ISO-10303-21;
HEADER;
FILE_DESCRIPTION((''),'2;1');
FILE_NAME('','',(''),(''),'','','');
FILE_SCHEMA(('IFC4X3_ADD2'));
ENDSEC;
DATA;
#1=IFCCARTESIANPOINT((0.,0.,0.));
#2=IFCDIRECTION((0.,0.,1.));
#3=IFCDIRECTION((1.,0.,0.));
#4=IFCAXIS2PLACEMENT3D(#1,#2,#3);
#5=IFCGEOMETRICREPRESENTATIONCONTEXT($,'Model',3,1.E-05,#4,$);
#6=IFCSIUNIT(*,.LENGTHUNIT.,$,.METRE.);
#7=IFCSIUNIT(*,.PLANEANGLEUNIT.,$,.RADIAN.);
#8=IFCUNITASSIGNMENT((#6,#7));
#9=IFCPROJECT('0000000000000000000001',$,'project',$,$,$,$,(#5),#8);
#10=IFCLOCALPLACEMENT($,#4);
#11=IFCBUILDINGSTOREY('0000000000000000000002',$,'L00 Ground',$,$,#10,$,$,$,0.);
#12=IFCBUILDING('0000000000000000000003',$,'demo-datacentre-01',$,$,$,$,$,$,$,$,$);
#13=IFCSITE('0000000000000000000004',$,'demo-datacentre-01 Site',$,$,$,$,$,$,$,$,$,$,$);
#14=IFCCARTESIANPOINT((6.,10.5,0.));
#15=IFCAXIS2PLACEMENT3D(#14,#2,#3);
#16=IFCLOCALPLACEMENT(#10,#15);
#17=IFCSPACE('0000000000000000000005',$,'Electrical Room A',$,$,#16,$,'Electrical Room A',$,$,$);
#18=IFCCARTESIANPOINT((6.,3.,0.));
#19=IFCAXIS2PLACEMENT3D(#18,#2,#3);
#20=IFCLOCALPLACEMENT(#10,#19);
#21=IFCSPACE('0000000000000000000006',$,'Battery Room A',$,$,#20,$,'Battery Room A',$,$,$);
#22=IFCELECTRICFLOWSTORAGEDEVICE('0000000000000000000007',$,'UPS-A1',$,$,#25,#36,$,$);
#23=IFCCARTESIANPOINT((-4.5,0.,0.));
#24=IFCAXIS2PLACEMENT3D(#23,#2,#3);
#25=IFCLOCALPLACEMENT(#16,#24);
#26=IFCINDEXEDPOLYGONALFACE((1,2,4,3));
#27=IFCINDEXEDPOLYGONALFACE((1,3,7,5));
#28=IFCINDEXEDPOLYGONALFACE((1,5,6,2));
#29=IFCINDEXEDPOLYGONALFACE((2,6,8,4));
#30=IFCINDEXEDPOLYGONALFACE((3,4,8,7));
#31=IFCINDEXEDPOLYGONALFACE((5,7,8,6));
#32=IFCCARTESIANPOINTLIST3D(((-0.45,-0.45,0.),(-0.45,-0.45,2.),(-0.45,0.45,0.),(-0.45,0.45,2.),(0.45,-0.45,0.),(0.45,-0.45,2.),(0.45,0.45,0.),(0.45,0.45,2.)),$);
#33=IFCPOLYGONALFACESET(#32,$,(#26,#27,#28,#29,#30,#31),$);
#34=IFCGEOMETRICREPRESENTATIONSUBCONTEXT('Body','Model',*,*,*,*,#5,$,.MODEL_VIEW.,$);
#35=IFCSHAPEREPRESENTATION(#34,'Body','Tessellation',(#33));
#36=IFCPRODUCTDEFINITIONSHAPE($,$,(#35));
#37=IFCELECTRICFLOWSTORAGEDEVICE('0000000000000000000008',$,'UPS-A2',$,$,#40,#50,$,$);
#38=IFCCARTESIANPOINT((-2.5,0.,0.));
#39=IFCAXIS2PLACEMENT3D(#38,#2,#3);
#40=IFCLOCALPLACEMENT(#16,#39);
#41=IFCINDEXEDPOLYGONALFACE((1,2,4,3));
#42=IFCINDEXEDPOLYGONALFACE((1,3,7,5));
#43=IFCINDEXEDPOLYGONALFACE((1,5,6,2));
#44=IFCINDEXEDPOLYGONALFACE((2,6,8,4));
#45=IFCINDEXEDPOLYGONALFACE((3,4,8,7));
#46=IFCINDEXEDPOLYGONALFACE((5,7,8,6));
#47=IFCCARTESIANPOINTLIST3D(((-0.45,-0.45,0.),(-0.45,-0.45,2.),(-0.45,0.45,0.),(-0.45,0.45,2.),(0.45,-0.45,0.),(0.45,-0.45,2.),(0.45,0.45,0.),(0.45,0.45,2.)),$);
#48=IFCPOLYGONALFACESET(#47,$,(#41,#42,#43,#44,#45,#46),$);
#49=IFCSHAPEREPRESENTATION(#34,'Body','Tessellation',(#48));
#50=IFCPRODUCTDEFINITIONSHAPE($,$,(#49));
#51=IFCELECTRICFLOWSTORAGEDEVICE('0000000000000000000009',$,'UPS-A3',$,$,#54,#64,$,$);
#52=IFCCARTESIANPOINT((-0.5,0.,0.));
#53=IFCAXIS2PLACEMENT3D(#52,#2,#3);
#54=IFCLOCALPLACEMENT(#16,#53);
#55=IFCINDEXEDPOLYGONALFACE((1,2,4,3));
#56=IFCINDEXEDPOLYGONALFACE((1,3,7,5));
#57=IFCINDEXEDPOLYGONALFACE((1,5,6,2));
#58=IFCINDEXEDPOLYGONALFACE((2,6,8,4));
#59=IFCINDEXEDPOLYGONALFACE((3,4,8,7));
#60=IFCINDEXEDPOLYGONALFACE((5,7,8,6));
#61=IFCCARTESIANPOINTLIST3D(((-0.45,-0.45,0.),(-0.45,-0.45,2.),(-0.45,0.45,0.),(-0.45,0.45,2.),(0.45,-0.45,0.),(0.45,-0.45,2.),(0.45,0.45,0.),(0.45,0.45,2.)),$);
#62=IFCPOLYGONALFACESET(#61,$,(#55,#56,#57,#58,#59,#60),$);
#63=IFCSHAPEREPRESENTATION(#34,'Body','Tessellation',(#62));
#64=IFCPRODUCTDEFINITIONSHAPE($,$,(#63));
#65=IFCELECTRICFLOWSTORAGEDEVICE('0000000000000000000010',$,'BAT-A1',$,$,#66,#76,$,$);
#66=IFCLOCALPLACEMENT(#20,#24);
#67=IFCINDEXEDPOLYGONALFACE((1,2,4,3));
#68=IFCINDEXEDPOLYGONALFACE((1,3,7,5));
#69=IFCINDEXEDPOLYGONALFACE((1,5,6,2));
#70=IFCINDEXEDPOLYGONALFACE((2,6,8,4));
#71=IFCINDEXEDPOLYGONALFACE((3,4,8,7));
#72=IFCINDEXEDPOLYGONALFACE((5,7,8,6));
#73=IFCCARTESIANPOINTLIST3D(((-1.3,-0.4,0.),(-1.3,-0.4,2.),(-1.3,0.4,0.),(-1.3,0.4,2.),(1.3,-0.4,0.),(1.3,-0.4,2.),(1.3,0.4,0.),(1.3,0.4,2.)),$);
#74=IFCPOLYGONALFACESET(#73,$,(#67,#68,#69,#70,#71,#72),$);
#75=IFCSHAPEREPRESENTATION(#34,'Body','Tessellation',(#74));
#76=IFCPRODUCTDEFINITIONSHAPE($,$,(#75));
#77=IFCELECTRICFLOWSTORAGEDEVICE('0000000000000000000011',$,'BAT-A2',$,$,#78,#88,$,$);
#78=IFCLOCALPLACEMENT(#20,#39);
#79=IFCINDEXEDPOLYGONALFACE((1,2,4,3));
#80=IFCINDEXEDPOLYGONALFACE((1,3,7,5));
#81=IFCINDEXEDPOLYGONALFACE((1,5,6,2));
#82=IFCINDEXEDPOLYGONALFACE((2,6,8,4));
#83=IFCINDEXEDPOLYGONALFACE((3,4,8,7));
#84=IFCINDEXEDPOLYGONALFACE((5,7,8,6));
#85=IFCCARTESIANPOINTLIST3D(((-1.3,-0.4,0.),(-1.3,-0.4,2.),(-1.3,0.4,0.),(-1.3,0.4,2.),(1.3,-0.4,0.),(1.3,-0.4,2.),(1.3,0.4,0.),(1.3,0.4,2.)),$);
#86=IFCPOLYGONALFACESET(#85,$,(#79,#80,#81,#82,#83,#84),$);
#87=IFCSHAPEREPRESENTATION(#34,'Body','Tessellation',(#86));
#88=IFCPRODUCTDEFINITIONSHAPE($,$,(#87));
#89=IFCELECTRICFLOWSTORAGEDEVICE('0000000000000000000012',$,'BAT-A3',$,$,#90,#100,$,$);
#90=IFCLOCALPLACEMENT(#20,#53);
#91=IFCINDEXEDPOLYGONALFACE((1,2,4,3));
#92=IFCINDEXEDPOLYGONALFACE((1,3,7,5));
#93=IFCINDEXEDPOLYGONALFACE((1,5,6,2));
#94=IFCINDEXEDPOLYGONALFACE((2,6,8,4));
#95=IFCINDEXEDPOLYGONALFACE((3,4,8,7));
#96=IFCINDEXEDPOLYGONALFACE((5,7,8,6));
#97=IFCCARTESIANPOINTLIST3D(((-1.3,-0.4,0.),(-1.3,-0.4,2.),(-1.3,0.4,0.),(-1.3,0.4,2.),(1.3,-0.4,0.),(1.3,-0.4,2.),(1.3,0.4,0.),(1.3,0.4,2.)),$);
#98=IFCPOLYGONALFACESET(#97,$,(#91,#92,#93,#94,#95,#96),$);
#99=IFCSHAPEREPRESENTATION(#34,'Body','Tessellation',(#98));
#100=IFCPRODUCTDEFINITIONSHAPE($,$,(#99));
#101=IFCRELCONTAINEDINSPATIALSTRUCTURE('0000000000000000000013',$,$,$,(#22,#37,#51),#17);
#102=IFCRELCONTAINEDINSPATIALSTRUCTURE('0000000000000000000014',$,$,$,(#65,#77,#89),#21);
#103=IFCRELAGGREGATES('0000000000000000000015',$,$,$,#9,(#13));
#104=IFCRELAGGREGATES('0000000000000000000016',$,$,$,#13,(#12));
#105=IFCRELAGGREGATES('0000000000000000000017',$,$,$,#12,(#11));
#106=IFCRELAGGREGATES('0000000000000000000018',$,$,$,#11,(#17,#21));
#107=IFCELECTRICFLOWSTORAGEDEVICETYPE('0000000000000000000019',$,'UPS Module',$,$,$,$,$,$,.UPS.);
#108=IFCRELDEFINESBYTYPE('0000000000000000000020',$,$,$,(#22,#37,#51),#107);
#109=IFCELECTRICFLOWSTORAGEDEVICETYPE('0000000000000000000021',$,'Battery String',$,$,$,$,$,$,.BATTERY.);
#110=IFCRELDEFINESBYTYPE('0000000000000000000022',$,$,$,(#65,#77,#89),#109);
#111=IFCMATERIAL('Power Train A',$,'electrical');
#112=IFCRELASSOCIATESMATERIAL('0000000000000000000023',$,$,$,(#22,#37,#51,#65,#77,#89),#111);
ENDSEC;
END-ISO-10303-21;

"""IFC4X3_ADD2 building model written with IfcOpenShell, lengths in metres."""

from ifc_helpers import new_model, si_unit, frame, origin_with_axes, place, context, subcontext, project, spatial, rectangle, extrude, material, type_object, element, save


model = new_model("IFC4X3_ADD2")

# Units and contexts
model_context = context("Model", 3, precision=1e-05, world=origin_with_axes())
body_context = subcontext(model_context, "Body", "Model", "MODEL_VIEW")
ifc_project = project(units=[si_unit("LENGTHUNIT", "METRE"), si_unit("PLANEANGLEUNIT", "RADIAN")], contexts=[model_context])

# Site, building, storey, space
site = spatial("IfcSite", under=ifc_project, Name="demo-datacentre-01 Site")
building = spatial("IfcBuilding", under=site, Name="demo-datacentre-01")
storey_placement = place(None, origin_with_axes())
storey = spatial("IfcBuildingStorey", under=building, at=storey_placement, Name="L00 Ground", Elevation=0.0)
space_1_placement = place(storey_placement, frame((6.0, 10.5, 0.0), z_axis=(0.0, 0.0, 1.0), x_axis=(1.0, 0.0, 0.0)))
space_1 = spatial("IfcSpace", under=storey, at=space_1_placement, Name="Electrical Room A", LongName="Electrical Room A")

# Shared definitions
ifc_material = material(Name="Power Train A", Category="electrical")

# Electric flow storage devices
electric_flow_storage_device_type_1 = type_object("IfcElectricFlowStorageDeviceType", Name="UPS Module", PredefinedType="UPS")
for number, where, z_axis, x_axis, name in (
    (1, (-4.5, 0.0, 0.0), (0.0, 0.0, 1.0), (1.0, 0.0, 0.0), "UPS-A1"),
    (2, (-2.5, 0.0, 0.0), (0.0, 0.0, 1.0), (1.0, 0.0, 0.0), "UPS-A2"),
    (3, (-0.5, 0.0, 0.0), (0.0, 0.0, 1.0), (1.0, 0.0, 0.0), "UPS-A3"),
):
    element("IfcElectricFlowStorageDevice", number, at=place(space_1_placement, frame(where, z_axis=z_axis, x_axis=x_axis)), inside=space_1, type_object=electric_flow_storage_device_type_1, material=ifc_material, Name=name, context=body_context, shape_type="SweptSolid", body=[
        extrude(rectangle(XDim=0.9, YDim=0.9), origin_with_axes(), (0.0, 0.0, 1.0), 2.0),
    ])

# Shared definitions
space_2_placement = place(storey_placement, frame((6.0, 3.0, 0.0), z_axis=(0.0, 0.0, 1.0), x_axis=(1.0, 0.0, 0.0)))
space_2 = spatial("IfcSpace", under=storey, at=space_2_placement, Name="Battery Room A", LongName="Battery Room A")

# Electric flow storage devices
electric_flow_storage_device_type_2 = type_object("IfcElectricFlowStorageDeviceType", Name="Battery String", PredefinedType="BATTERY")
for number, where, z_axis, x_axis, name in (
    (4, (-4.5, 0.0, 0.0), (0.0, 0.0, 1.0), (1.0, 0.0, 0.0), "BAT-A1"),
    (5, (-2.5, 0.0, 0.0), (0.0, 0.0, 1.0), (1.0, 0.0, 0.0), "BAT-A2"),
    (6, (-0.5, 0.0, 0.0), (0.0, 0.0, 1.0), (1.0, 0.0, 0.0), "BAT-A3"),
):
    element("IfcElectricFlowStorageDevice", number, at=place(space_2_placement, frame(where, z_axis=z_axis, x_axis=x_axis)), inside=space_2, type_object=electric_flow_storage_device_type_2, material=ifc_material, Name=name, context=body_context, shape_type="SweptSolid", body=[
        extrude(rectangle(XDim=2.6, YDim=0.8), origin_with_axes(), (0.0, 0.0, 1.0), 2.0),
    ])

save(model, "model.ifc")
